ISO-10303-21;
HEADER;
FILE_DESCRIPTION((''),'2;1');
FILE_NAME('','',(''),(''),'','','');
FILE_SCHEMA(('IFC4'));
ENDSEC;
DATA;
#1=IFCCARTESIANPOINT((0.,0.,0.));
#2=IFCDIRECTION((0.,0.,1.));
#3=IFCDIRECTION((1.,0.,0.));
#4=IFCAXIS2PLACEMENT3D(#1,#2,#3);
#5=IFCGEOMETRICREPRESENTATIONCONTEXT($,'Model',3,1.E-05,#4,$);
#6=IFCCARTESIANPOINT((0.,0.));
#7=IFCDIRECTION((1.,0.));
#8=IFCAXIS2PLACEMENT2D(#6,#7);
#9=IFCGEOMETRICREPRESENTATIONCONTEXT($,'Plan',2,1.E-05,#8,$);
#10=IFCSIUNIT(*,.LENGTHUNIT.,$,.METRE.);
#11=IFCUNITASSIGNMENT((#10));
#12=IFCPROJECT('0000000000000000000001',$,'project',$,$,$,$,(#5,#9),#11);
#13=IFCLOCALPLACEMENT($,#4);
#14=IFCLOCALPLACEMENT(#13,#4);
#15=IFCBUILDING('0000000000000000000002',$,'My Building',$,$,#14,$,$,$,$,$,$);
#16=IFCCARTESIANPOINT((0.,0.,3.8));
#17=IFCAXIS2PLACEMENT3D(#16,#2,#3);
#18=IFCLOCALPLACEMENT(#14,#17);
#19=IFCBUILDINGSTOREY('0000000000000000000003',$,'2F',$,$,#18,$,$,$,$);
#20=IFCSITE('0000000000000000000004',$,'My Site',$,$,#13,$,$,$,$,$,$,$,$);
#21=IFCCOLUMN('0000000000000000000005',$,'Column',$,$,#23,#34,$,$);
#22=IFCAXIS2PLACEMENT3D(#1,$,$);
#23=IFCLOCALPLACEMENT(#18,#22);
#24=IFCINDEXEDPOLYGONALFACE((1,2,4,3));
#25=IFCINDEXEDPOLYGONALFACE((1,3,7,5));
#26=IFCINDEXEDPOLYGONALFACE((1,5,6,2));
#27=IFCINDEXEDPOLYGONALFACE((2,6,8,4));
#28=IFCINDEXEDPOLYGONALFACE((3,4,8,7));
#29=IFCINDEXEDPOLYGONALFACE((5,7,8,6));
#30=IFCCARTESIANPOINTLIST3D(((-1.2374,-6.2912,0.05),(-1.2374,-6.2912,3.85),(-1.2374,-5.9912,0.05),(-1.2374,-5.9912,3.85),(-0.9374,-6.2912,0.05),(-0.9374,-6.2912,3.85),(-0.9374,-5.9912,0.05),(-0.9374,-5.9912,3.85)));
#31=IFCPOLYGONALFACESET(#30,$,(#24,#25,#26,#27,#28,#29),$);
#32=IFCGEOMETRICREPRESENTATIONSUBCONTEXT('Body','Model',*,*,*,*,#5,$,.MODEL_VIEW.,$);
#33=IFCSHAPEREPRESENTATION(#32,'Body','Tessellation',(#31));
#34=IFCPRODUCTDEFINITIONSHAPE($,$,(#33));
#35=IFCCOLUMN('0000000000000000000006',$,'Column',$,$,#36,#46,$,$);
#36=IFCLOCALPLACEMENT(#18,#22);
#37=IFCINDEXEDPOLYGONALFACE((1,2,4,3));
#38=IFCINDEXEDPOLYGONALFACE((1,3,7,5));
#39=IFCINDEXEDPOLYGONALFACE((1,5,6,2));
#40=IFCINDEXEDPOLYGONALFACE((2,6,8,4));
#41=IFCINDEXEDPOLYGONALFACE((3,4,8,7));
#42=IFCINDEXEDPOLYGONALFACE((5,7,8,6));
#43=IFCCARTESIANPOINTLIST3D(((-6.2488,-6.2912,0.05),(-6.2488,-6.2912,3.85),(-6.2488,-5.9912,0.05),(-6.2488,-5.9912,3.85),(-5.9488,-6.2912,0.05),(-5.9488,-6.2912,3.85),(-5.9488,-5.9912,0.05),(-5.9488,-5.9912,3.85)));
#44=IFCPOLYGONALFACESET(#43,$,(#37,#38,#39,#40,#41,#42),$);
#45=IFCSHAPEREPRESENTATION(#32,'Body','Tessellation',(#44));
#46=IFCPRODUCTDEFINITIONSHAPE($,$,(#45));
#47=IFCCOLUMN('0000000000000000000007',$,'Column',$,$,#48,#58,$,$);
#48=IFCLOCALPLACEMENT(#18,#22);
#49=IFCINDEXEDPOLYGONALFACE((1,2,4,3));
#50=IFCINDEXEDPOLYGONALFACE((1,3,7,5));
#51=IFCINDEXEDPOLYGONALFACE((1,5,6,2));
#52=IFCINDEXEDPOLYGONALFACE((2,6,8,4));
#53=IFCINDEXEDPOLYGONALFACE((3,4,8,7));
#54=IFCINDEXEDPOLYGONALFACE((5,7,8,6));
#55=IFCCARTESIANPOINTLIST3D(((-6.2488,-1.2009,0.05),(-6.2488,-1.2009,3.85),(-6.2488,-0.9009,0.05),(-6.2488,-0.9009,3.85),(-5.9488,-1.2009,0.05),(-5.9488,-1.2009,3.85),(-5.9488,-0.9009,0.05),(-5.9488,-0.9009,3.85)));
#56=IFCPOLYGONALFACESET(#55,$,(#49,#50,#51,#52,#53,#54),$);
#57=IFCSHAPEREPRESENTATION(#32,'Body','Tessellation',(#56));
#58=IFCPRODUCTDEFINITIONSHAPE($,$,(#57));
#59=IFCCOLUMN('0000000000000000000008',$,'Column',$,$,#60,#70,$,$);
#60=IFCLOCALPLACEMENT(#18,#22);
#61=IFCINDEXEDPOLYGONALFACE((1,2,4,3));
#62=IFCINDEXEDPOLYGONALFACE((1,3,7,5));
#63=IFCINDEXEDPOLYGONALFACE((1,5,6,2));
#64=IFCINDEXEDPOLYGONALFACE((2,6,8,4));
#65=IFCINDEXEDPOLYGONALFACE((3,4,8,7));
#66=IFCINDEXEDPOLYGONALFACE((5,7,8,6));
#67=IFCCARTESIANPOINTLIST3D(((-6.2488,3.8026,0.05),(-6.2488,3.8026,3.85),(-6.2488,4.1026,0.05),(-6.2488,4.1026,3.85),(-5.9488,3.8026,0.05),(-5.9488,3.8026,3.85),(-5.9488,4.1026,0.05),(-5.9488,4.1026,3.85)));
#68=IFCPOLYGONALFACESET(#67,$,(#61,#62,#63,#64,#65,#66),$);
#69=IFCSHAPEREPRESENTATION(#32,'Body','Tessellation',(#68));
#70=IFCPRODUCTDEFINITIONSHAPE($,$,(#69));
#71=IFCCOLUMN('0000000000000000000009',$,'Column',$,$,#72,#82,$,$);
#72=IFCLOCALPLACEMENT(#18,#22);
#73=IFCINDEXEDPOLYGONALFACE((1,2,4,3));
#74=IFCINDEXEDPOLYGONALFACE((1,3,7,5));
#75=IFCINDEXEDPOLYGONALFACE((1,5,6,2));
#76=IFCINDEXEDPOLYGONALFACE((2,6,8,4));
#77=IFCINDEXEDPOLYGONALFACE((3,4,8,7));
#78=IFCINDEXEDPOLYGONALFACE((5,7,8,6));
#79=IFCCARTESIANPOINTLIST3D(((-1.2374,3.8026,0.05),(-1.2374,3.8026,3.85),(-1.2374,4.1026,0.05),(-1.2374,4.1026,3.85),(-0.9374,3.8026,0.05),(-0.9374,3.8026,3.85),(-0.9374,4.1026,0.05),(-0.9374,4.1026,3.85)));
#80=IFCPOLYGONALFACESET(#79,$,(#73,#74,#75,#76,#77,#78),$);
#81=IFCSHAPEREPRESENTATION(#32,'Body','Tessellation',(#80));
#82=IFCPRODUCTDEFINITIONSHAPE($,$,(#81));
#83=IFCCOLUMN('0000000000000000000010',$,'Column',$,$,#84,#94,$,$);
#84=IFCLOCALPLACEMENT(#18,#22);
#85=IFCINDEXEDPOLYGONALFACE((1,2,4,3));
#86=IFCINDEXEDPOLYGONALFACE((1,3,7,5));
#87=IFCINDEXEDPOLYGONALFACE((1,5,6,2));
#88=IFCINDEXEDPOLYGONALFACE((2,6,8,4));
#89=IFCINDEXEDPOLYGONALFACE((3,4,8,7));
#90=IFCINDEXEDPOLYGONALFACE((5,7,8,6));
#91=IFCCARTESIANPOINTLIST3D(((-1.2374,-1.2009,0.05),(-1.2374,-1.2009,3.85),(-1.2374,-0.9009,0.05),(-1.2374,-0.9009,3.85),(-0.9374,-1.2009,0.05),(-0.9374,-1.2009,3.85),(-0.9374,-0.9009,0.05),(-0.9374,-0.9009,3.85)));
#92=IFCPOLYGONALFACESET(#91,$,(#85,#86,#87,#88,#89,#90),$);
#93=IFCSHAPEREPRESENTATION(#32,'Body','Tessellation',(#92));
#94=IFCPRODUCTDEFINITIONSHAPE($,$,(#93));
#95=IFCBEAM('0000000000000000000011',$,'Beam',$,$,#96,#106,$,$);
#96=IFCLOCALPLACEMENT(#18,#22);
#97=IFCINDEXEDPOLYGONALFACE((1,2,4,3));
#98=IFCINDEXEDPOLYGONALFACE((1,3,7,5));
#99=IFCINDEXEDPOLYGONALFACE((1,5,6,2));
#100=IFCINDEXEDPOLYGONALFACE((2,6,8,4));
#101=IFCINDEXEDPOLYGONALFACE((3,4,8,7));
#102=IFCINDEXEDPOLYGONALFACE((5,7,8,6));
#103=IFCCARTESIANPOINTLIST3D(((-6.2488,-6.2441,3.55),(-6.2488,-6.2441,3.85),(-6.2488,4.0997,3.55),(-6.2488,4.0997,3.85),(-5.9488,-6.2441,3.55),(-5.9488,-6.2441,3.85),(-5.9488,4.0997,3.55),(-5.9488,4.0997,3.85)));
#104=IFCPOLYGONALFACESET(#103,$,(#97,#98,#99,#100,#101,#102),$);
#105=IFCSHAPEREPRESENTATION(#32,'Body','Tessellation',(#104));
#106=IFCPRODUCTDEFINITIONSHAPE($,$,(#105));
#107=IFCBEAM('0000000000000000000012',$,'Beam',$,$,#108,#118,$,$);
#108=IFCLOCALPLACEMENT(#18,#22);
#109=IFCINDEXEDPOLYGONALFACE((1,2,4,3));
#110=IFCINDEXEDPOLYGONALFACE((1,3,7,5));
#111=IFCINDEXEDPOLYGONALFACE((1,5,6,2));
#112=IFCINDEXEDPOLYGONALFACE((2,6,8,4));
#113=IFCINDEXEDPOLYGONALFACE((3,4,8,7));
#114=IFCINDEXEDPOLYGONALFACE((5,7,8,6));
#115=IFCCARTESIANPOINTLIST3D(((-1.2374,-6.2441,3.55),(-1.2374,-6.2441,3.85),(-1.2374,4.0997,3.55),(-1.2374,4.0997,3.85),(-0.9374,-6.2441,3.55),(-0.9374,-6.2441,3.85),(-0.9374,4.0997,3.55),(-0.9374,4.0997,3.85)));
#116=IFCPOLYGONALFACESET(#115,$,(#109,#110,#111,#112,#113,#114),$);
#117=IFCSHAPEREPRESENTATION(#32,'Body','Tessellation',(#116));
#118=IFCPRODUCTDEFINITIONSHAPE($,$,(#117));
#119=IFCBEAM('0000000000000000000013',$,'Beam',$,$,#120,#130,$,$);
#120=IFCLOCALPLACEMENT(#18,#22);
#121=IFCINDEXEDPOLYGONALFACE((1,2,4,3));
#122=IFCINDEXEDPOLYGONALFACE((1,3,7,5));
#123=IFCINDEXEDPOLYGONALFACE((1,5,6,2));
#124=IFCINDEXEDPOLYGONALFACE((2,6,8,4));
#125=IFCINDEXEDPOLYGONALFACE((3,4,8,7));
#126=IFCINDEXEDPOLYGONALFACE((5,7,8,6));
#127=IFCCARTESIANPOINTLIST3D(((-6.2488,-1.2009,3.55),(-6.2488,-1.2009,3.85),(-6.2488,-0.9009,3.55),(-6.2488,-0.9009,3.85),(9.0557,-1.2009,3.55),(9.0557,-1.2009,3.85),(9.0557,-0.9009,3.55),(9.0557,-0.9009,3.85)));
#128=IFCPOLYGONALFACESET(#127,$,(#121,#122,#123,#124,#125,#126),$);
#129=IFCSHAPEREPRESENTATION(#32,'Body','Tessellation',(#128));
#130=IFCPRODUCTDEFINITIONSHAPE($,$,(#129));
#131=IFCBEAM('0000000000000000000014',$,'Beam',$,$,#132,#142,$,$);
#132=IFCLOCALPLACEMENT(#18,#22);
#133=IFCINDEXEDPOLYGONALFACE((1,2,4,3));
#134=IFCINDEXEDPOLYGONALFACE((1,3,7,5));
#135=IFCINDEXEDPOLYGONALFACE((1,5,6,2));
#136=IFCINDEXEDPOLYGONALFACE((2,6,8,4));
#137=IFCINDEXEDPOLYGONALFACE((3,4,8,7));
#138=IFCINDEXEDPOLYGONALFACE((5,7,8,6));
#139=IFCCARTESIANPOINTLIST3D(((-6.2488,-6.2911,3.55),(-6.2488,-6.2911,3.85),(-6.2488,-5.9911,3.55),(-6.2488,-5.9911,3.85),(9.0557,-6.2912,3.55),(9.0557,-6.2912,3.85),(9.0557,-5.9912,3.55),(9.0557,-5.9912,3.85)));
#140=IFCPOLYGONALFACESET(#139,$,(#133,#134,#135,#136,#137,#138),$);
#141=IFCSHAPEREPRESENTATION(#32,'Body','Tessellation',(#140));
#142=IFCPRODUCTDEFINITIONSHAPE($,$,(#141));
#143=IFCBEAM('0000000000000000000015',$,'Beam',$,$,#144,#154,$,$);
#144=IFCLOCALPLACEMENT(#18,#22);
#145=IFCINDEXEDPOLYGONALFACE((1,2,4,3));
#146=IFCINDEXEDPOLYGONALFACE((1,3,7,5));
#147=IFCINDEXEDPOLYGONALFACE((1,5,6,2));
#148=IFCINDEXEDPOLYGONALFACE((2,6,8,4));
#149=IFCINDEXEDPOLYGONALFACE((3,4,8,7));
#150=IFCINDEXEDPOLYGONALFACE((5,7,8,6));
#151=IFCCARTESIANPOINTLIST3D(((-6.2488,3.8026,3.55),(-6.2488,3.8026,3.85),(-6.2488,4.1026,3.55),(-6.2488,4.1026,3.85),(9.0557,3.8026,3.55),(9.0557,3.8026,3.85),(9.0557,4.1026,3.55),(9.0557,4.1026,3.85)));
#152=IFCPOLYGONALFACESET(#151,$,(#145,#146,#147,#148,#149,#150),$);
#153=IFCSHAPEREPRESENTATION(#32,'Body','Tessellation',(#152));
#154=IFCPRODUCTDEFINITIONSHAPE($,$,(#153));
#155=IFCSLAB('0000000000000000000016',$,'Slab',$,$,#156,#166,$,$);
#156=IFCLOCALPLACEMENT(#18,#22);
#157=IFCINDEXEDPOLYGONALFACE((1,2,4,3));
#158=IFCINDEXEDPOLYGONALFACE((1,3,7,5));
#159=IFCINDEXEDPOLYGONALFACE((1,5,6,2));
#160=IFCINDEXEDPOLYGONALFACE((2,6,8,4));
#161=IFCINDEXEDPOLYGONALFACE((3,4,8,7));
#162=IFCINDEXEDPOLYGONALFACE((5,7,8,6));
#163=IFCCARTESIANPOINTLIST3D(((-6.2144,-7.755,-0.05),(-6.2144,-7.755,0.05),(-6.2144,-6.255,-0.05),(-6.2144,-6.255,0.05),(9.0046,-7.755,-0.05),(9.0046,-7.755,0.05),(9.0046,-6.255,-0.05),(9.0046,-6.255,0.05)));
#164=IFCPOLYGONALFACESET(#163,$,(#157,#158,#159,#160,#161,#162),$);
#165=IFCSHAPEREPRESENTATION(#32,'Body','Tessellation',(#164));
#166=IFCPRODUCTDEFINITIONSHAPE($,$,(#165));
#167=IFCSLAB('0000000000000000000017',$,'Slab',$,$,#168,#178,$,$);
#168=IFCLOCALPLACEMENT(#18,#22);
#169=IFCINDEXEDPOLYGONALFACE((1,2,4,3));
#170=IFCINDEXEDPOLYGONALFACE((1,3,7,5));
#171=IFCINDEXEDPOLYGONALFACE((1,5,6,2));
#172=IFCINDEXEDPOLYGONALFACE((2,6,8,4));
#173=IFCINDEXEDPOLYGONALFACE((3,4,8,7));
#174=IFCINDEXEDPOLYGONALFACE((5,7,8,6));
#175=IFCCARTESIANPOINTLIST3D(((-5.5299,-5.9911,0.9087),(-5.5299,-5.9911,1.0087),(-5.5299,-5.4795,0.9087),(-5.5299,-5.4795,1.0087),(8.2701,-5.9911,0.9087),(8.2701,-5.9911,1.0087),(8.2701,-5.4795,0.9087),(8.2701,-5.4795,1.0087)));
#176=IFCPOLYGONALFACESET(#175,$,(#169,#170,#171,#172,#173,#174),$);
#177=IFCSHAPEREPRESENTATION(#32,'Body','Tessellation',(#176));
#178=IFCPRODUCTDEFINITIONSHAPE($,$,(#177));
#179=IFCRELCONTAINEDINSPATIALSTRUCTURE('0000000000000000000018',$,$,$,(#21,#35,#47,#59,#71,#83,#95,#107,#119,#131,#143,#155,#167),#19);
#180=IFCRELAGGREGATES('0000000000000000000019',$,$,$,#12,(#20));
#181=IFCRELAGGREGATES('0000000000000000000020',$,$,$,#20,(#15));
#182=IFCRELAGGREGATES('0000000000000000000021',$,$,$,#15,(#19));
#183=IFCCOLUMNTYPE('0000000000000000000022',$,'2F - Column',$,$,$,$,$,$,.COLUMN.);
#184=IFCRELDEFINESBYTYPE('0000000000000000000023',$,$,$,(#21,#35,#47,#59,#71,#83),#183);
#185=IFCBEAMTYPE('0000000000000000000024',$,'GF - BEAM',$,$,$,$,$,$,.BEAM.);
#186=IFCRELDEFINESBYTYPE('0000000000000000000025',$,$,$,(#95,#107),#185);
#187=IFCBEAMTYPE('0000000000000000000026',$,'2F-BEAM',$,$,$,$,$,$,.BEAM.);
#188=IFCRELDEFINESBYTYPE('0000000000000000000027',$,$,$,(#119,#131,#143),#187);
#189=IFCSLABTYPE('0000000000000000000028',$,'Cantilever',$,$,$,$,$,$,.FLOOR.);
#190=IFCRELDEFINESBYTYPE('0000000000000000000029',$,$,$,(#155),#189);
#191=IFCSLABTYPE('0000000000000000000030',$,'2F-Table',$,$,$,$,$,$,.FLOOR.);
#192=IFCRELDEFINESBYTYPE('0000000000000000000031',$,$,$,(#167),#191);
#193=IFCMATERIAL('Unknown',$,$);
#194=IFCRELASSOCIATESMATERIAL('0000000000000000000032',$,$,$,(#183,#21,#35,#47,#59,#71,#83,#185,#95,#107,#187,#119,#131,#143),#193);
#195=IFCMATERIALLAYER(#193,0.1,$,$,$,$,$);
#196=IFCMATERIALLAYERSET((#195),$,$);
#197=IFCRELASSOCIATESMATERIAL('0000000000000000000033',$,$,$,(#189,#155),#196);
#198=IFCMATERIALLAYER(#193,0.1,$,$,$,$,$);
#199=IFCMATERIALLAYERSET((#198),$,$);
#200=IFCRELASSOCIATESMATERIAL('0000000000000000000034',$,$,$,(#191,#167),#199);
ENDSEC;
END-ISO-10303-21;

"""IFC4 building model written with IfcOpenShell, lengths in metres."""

from ifc_helpers import new_model, si_unit, frame, origin_with_axes, origin_2d_with_axis, place, context, subcontext, project, spatial, indexed_curve, rectangle, outline, extrude, material, layer, layer_set, layer_usage, material_profile, profile_set, profile_usage, type_object, element, save


model = new_model("IFC4")

# Units and contexts
model_context = context("Model", 3, precision=1e-05, world=origin_with_axes())
plan_context = context("Plan", 2, precision=1e-05, world=origin_2d_with_axis())
body_context_1 = subcontext(model_context, "Body", "Model", "MODEL_VIEW")
ifc_project = project(units=[si_unit("LENGTHUNIT", "METRE")], contexts=[model_context, plan_context])

# Site, building, storey
site_placement = place(None, origin_with_axes())
site = spatial("IfcSite", under=ifc_project, at=site_placement, Name="My Site")
building_placement = place(site_placement, origin_with_axes())
building = spatial("IfcBuilding", under=site, at=building_placement, Name="My Building")
storey_placement = place(building_placement, frame((0.0, 0.0, 3.8), z_axis=(0.0, 0.0, 1.0), x_axis=(1.0, 0.0, 0.0)))
storey = spatial("IfcBuildingStorey", under=building, at=storey_placement, Name="2F")

# Columns
ifc_material = material(Name="Unknown")
ifc_material_profile_1 = material_profile(ifc_material, rectangle(XDim=0.3, YDim=0.3))
ifc_profile_set_1 = profile_set([ifc_material_profile_1])
ifc_profile_usage_1 = profile_usage(ifc_profile_set_1, cardinal=5)
column_type = type_object("IfcColumnType", Name="2F - Column", PredefinedType="COLUMN", material=ifc_profile_set_1)
column_1_placement = place(storey_placement, frame((-1.0874, -6.1412, 0.05), z_axis=(0.0, 0.0, 1.0), x_axis=(1.0, 0.0, 0.0)))
element("IfcColumn", 1, at=column_1_placement, inside=storey, type_object=column_type, material=ifc_profile_usage_1, Name="Column", context=body_context_1, shape_type="SweptSolid", body=[
    extrude(rectangle(XDim=0.3, YDim=0.3), origin_with_axes(), (0.0, 0.0, 1.0), 3.8),
])
ifc_profile_usage_2 = profile_usage(ifc_profile_set_1, cardinal=5)
column_2_placement = place(storey_placement, frame((-6.0988, -6.1412, 0.05), z_axis=(0.0, 0.0, 1.0), x_axis=(1.0, 0.0, 0.0)))
element("IfcColumn", 2, at=column_2_placement, inside=storey, type_object=column_type, material=ifc_profile_usage_2, Name="Column", context=body_context_1, shape_type="SweptSolid", body=[
    extrude(rectangle(XDim=0.3, YDim=0.3), origin_with_axes(), (0.0, 0.0, 1.0), 3.8),
])
ifc_profile_usage_3 = profile_usage(ifc_profile_set_1, cardinal=5)
column_3_placement = place(storey_placement, frame((-6.0988, -1.0509, 0.05), z_axis=(0.0, 0.0, 1.0), x_axis=(1.0, 0.0, 0.0)))
element("IfcColumn", 3, at=column_3_placement, inside=storey, type_object=column_type, material=ifc_profile_usage_3, Name="Column", context=body_context_1, shape_type="SweptSolid", body=[
    extrude(rectangle(XDim=0.3, YDim=0.3), origin_with_axes(), (0.0, 0.0, 1.0), 3.8),
])
ifc_profile_usage_4 = profile_usage(ifc_profile_set_1, cardinal=5)
column_4_placement = place(storey_placement, frame((-6.0988, 3.9526, 0.05), z_axis=(0.0, 0.0, 1.0), x_axis=(1.0, 0.0, 0.0)))
element("IfcColumn", 4, at=column_4_placement, inside=storey, type_object=column_type, material=ifc_profile_usage_4, Name="Column", context=body_context_1, shape_type="SweptSolid", body=[
    extrude(rectangle(XDim=0.3, YDim=0.3), origin_with_axes(), (0.0, 0.0, 1.0), 3.8),
])
ifc_profile_usage_5 = profile_usage(ifc_profile_set_1, cardinal=5)
column_5_placement = place(storey_placement, frame((-1.0874, 3.9526, 0.05), z_axis=(0.0, 0.0, 1.0), x_axis=(1.0, 0.0, 0.0)))
element("IfcColumn", 5, at=column_5_placement, inside=storey, type_object=column_type, material=ifc_profile_usage_5, Name="Column", context=body_context_1, shape_type="SweptSolid", body=[
    extrude(rectangle(XDim=0.3, YDim=0.3), origin_with_axes(), (0.0, 0.0, 1.0), 3.8),
])
ifc_profile_usage_6 = profile_usage(ifc_profile_set_1, cardinal=5)
column_6_placement = place(storey_placement, frame((-1.0874, -1.0509, 0.05), z_axis=(0.0, 0.0, 1.0), x_axis=(1.0, 0.0, 0.0)))
element("IfcColumn", 6, at=column_6_placement, inside=storey, type_object=column_type, material=ifc_profile_usage_6, Name="Column", context=body_context_1, shape_type="SweptSolid", body=[
    extrude(rectangle(XDim=0.3, YDim=0.3), origin_with_axes(), (0.0, 0.0, 1.0), 3.8),
])

# Beams
ifc_material_profile_2 = material_profile(ifc_material, rectangle(XDim=0.3, YDim=0.3))
ifc_profile_set_2 = profile_set([ifc_material_profile_2])
ifc_profile_usage_7 = profile_usage(ifc_profile_set_2, cardinal=5)
beam_type_1 = type_object("IfcBeamType", Name="GF - BEAM", PredefinedType="BEAM", material=ifc_profile_set_2)
beam_1_placement = place(storey_placement, frame((-6.0988, -6.2441, 3.7), z_axis=(0.0, 1.0, 0.0), x_axis=(-1.0, 0.0, 0.0)))
element("IfcBeam", 7, at=beam_1_placement, inside=storey, type_object=beam_type_1, material=ifc_profile_usage_7, Name="Beam", context=body_context_1, shape_type="SweptSolid", body=[
    extrude(rectangle(XDim=0.3, YDim=0.3), origin_with_axes(), (0.0, 0.0, 1.0), 10.3438),
])
ifc_profile_usage_8 = profile_usage(ifc_profile_set_2, cardinal=5)
beam_2_placement = place(storey_placement, frame((-1.0874, -6.2441, 3.7), z_axis=(0.0, 1.0, 0.0), x_axis=(-1.0, 0.0, 0.0)))
element("IfcBeam", 8, at=beam_2_placement, inside=storey, type_object=beam_type_1, material=ifc_profile_usage_8, Name="Beam", context=body_context_1, shape_type="SweptSolid", body=[
    extrude(rectangle(XDim=0.3, YDim=0.3), origin_with_axes(), (0.0, 0.0, 1.0), 10.3438),
])
ifc_material_profile_3 = material_profile(ifc_material, rectangle(XDim=0.3, YDim=0.3))
ifc_profile_set_3 = profile_set([ifc_material_profile_3])
ifc_profile_usage_9 = profile_usage(ifc_profile_set_3, cardinal=5)
beam_type_2 = type_object("IfcBeamType", Name="2F-BEAM", PredefinedType="BEAM", material=ifc_profile_set_3)
beam_3_placement = place(storey_placement, frame((-6.2488, -1.0509, 3.7), z_axis=(1.0, -0.000001, 0.000001), x_axis=(0.000001, 1.0, 0.0)))
element("IfcBeam", 9, at=beam_3_placement, inside=storey, type_object=beam_type_2, material=ifc_profile_usage_9, Name="Beam", context=body_context_1, shape_type="SweptSolid", body=[
    extrude(rectangle(XDim=0.3, YDim=0.3), origin_with_axes(), (0.0, 0.0, 1.0), 15.3045),
])
ifc_profile_usage_10 = profile_usage(ifc_profile_set_3, cardinal=5)
beam_4_placement = place(storey_placement, frame((-6.2488, -6.1411, 3.7), z_axis=(1.0, -0.000001, 0.000001), x_axis=(0.000001, 1.0, 0.0)))
element("IfcBeam", 10, at=beam_4_placement, inside=storey, type_object=beam_type_2, material=ifc_profile_usage_10, Name="Beam", context=body_context_1, shape_type="SweptSolid", body=[
    extrude(rectangle(XDim=0.3, YDim=0.3), origin_with_axes(), (0.0, 0.0, 1.0), 15.3045),
])
ifc_profile_usage_11 = profile_usage(ifc_profile_set_3, cardinal=5)
beam_5_placement = place(storey_placement, frame((-6.2488, 3.9526, 3.7), z_axis=(1.0, -0.000001, 0.000001), x_axis=(0.000001, 1.0, 0.0)))
element("IfcBeam", 11, at=beam_5_placement, inside=storey, type_object=beam_type_2, material=ifc_profile_usage_11, Name="Beam", context=body_context_1, shape_type="SweptSolid", body=[
    extrude(rectangle(XDim=0.3, YDim=0.3), origin_with_axes(), (0.0, 0.0, 1.0), 15.3045),
])

# Slabs
ifc_layer_1 = layer(ifc_material, 0.1)
ifc_layer_set_1 = layer_set([ifc_layer_1])
ifc_layer_usage_1 = layer_usage(ifc_layer_set_1, "AXIS3", "POSITIVE", -0.1)
slab_type_1 = type_object("IfcSlabType", Name="Cantilever", PredefinedType="FLOOR", material=ifc_layer_set_1)
slab_1_placement = place(storey_placement, frame((-6.2144, -6.255, 0.05), z_axis=(0.0, 0.0, 1.0), x_axis=(1.0, 0.0, 0.0)))
element("IfcSlab", 12, at=slab_1_placement, inside=storey, type_object=slab_type_1, material=ifc_layer_usage_1, Name="Slab", context=body_context_1, shape_type="SweptSolid", body=[
    extrude(outline(indexed_curve([(0.0, 0.0), (15.219, 0.0), (15.219, -1.5), (0.0, -1.5), (0.0, 0.0)])), frame((0.0, 0.0, -0.1), z_axis=(0.0, 0.0, 1.0), x_axis=(1.0, 0.0, 0.0)), (0.0, 0.0, 1.0), 0.1),
])
ifc_layer_2 = layer(ifc_material, 0.1)
ifc_layer_set_2 = layer_set([ifc_layer_2])
ifc_layer_usage_2 = layer_usage(ifc_layer_set_2, "AXIS3", "POSITIVE", -0.1)
slab_type_2 = type_object("IfcSlabType", Name="2F-Table", PredefinedType="FLOOR", material=ifc_layer_set_2)
slab_2_placement = place(storey_placement, frame((-5.5299, -5.9911, 1.0087), z_axis=(0.0, 0.0, 1.0), x_axis=(1.0, 0.0, 0.0)))
element("IfcSlab", 13, at=slab_2_placement, inside=storey, type_object=slab_type_2, material=ifc_layer_usage_2, Name="Slab", context=body_context_1, shape_type="SweptSolid", body=[
    extrude(outline(indexed_curve([(0.0, 0.0), (0.0, 0.5117), (13.8, 0.5117), (13.8, 0.0), (0.0, 0.0)])), frame((0.0, 0.0, -0.1), z_axis=(0.0, 0.0, 1.0), x_axis=(1.0, 0.0, 0.0)), (0.0, 0.0, 1.0), 0.1),
])

save(model, "model.ifc")
